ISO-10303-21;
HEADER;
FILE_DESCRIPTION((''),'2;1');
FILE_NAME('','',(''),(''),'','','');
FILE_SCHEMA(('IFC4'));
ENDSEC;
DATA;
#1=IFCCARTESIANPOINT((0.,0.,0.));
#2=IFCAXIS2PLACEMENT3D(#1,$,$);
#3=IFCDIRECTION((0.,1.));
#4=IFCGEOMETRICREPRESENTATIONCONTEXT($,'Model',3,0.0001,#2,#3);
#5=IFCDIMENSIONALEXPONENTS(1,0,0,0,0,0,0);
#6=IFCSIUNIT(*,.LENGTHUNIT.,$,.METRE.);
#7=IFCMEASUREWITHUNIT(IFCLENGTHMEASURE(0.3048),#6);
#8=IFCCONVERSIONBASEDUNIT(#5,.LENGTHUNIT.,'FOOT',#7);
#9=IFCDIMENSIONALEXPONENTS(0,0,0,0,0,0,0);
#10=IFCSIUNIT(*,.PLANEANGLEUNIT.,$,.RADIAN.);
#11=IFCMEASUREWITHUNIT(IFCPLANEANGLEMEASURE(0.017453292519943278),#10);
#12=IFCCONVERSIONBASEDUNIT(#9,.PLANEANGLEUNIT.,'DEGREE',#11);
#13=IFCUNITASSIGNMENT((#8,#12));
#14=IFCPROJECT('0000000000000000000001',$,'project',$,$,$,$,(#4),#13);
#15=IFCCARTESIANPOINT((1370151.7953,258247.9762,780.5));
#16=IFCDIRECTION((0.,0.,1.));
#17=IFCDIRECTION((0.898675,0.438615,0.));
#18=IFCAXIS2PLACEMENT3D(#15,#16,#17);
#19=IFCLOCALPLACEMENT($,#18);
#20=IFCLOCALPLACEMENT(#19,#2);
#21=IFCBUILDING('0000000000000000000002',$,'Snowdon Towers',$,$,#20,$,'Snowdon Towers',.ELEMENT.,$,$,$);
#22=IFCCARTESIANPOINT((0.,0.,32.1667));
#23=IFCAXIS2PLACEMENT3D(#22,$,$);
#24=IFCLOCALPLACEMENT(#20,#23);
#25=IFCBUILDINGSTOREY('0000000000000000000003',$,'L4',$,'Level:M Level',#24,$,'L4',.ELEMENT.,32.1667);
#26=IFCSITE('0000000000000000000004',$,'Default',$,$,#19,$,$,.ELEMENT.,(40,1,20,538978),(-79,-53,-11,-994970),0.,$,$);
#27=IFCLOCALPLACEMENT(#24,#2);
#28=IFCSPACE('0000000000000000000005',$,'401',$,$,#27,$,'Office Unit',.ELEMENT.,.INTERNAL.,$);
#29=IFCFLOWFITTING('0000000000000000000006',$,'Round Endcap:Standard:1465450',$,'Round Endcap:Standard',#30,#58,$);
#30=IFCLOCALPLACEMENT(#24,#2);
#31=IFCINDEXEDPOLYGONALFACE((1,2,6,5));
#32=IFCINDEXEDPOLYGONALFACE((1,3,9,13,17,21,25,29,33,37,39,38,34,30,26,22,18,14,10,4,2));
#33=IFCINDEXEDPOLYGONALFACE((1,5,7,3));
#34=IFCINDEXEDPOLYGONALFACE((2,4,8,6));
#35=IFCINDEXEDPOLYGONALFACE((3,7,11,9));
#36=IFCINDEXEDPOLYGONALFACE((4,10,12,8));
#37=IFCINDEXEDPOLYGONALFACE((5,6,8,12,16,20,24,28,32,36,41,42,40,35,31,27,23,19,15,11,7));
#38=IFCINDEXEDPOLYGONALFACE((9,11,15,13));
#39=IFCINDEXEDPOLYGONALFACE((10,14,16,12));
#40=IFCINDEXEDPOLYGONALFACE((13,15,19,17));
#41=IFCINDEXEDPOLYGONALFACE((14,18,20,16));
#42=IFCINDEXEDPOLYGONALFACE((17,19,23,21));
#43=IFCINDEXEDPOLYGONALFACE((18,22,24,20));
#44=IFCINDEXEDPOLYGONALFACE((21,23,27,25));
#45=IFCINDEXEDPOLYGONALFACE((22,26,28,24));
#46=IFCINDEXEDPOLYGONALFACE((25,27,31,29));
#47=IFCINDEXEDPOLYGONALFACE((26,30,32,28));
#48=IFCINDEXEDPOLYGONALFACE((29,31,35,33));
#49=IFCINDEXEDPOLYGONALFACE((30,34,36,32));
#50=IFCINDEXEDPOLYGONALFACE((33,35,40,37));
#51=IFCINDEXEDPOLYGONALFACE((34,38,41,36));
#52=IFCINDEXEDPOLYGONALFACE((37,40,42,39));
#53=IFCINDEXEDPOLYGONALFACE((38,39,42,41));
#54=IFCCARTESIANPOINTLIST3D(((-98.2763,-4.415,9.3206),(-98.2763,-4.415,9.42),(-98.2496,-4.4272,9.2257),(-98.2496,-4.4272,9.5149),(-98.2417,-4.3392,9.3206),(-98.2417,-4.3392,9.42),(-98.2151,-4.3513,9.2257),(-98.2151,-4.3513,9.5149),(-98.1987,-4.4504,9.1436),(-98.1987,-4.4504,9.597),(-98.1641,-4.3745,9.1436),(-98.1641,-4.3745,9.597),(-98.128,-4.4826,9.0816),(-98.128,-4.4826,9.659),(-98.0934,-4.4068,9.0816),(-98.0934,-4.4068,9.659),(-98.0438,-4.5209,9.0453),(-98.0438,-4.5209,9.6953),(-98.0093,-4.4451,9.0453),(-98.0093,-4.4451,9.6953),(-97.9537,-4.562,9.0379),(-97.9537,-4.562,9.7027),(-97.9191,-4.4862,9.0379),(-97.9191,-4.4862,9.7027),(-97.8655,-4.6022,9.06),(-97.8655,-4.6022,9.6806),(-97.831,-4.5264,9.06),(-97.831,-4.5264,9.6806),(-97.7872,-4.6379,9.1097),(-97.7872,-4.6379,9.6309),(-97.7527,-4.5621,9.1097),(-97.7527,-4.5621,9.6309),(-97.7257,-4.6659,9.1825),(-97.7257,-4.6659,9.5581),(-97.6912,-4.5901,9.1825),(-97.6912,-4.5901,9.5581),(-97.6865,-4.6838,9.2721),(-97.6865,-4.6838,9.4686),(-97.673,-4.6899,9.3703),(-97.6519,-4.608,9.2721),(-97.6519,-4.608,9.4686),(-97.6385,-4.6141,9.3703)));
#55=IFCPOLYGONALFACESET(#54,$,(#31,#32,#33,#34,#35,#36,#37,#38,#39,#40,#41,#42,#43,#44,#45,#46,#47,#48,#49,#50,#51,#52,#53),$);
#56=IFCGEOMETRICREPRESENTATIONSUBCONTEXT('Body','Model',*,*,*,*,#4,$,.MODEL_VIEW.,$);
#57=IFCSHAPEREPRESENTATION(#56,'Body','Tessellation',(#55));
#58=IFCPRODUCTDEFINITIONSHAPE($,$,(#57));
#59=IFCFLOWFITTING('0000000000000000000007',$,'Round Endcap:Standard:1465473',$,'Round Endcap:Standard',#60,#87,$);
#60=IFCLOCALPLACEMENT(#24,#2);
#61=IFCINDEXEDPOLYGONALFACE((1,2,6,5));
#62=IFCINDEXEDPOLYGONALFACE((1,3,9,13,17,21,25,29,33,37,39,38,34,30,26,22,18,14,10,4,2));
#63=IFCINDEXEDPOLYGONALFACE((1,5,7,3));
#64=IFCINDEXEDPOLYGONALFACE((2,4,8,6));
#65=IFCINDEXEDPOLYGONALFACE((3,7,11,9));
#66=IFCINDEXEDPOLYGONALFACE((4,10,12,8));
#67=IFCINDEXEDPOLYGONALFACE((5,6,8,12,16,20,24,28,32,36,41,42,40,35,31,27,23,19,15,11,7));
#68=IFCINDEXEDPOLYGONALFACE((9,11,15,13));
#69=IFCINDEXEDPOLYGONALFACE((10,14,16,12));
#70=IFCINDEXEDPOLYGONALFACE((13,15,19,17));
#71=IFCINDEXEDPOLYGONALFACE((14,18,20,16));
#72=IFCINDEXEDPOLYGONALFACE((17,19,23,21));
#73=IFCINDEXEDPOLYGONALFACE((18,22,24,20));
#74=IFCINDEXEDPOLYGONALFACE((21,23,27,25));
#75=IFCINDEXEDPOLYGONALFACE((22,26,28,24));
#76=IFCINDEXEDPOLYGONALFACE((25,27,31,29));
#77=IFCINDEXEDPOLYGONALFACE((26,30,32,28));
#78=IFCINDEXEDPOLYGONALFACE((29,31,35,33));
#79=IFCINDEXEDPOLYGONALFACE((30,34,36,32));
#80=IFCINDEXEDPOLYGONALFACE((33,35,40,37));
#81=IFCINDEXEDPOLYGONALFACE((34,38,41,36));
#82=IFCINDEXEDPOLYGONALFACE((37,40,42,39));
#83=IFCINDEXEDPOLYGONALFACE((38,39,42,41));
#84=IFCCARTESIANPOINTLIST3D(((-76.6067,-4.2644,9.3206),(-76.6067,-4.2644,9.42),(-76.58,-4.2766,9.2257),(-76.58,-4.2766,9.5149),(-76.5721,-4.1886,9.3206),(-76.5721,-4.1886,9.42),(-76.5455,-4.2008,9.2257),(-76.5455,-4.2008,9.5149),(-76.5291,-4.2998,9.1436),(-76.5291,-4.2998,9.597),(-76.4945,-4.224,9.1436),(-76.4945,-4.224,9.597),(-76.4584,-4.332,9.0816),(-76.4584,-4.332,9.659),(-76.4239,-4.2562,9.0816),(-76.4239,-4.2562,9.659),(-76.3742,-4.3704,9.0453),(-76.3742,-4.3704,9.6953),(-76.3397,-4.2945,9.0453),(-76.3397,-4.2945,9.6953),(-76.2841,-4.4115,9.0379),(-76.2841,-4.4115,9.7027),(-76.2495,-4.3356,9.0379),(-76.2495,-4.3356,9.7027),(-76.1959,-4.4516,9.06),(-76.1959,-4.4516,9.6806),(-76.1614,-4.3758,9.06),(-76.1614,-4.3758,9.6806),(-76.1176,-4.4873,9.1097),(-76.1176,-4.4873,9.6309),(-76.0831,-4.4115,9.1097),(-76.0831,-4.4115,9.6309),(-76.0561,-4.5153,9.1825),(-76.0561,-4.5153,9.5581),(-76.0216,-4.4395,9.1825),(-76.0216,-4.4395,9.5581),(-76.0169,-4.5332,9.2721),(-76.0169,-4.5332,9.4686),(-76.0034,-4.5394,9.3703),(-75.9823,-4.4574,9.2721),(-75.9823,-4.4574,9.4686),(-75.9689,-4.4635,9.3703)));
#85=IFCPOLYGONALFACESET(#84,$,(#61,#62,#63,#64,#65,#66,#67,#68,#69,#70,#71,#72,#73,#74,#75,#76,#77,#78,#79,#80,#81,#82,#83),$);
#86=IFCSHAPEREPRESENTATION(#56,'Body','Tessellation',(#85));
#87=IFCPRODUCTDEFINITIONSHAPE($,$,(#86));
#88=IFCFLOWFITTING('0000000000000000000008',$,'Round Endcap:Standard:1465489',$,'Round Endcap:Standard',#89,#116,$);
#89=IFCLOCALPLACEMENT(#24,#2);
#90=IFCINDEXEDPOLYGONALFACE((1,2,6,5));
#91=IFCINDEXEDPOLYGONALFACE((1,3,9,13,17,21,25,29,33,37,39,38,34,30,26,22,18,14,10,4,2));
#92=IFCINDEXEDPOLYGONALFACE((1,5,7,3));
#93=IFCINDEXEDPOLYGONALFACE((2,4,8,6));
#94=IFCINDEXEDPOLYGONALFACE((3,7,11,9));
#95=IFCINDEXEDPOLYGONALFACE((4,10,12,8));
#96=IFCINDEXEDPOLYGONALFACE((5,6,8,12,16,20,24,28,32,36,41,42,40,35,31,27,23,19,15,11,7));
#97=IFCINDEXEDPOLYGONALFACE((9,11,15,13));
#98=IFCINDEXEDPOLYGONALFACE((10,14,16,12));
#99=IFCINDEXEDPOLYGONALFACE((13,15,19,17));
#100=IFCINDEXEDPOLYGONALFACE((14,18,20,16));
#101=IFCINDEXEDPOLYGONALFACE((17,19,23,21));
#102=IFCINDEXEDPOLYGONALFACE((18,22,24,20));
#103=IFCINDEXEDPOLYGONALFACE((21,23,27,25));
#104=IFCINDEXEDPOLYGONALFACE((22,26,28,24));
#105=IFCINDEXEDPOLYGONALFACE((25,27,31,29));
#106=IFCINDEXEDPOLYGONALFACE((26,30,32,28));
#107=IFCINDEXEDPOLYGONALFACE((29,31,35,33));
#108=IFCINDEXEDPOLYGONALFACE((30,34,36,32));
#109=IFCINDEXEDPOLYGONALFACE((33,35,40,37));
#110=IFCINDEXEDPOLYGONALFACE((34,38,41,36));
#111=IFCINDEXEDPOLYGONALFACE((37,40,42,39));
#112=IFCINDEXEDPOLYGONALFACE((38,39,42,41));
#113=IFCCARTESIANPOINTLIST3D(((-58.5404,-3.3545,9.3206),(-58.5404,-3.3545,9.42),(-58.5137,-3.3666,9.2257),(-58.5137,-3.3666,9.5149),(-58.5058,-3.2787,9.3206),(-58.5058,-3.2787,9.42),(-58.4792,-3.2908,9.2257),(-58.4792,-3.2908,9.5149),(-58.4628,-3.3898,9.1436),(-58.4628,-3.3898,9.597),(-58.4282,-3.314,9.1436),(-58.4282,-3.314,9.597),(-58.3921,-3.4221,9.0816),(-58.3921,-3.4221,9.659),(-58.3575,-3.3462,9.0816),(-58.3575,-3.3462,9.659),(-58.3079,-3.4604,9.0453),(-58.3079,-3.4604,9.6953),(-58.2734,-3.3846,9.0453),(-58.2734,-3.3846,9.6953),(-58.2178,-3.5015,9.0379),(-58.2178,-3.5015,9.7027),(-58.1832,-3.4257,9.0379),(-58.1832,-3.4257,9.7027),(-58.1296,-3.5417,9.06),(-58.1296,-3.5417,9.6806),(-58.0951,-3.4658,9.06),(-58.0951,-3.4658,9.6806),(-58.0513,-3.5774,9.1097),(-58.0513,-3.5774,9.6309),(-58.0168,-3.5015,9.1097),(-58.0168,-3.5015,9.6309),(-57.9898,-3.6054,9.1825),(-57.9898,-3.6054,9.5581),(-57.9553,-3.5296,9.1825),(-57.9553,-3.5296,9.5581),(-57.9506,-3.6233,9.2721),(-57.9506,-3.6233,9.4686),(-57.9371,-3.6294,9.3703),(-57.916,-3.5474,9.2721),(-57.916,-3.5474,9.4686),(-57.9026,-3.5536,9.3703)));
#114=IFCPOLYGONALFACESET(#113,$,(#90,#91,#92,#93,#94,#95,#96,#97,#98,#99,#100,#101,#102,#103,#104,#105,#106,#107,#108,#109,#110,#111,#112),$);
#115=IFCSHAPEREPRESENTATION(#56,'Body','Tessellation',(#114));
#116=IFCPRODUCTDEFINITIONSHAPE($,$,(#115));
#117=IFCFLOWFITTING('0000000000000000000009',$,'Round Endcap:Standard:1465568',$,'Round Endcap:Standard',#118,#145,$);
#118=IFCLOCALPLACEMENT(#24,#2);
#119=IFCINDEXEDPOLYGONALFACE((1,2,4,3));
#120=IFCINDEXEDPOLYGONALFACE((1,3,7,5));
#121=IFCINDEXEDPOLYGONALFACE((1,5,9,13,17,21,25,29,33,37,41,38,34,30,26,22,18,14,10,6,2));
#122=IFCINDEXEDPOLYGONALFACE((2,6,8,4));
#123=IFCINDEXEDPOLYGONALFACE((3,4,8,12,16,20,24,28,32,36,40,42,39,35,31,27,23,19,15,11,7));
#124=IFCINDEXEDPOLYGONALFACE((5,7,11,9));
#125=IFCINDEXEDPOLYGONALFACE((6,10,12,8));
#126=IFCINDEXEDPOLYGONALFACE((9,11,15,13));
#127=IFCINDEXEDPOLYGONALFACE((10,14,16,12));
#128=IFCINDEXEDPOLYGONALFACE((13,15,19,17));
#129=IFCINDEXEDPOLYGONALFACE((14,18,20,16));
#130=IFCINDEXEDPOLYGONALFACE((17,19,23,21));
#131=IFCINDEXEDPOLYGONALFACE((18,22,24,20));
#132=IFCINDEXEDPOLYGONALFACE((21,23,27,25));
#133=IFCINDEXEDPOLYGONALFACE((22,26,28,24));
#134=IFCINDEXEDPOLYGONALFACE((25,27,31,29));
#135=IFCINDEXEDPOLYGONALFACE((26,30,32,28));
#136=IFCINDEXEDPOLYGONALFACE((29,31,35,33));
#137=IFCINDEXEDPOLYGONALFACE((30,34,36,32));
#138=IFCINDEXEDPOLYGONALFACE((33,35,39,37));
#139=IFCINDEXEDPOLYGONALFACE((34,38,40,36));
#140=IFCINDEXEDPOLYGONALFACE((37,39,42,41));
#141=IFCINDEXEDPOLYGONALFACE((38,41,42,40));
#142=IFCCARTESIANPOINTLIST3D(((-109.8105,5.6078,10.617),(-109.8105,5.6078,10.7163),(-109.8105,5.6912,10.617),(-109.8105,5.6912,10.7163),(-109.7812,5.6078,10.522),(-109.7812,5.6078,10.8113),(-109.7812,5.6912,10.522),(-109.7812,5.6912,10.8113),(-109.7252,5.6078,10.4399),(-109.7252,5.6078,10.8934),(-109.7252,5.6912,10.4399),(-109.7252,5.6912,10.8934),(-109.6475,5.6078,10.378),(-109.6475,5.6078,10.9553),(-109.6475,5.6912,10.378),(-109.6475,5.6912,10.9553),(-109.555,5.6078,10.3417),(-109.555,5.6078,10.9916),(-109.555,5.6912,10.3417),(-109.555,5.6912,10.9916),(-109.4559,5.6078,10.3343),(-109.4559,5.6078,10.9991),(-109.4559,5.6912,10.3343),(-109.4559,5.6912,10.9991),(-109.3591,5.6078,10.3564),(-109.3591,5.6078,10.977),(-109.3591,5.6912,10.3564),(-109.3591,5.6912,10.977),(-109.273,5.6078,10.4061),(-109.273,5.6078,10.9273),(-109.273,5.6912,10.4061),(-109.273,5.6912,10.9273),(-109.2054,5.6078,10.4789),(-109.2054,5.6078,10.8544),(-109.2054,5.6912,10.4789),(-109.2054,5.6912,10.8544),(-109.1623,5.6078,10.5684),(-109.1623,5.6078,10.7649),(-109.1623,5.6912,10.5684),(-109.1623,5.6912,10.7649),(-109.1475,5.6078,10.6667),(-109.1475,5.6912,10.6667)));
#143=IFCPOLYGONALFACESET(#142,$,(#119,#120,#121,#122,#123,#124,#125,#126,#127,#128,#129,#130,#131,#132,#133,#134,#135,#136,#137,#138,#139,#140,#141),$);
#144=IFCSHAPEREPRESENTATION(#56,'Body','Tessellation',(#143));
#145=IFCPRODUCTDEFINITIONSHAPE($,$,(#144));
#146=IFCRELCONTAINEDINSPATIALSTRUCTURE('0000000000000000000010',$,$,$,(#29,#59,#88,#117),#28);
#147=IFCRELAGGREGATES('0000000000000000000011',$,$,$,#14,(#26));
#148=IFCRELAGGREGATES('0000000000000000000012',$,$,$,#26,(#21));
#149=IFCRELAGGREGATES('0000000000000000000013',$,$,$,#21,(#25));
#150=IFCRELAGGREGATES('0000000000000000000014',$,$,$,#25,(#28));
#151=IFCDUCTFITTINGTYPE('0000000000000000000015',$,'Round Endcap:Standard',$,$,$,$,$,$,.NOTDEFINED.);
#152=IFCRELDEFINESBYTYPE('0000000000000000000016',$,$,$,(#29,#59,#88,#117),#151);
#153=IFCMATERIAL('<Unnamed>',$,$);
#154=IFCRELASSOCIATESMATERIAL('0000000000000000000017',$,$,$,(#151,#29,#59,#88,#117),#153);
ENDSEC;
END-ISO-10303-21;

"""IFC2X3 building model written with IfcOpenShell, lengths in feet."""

from ifc_helpers import new_model, entity, si_unit, converted_unit, direction, frame, frame_2d, origin, place, context, subcontext, project, spatial, circle, extrude, source, transform, mapped, material, type_object, type_shapes, element, save


model = new_model("IFC2X3")

# Units and contexts
model_context = context("Model", 3, precision=0.0001, world=origin(), true_north=direction((0.0, 1.0)))
body_context = subcontext(model_context, "Body", "Model", "MODEL_VIEW")
ifc_project = project(units=[converted_unit("LENGTHUNIT", "FOOT", entity("IfcLengthMeasure", 0.3048), si_unit("LENGTHUNIT", "METRE"), dimensions=[1, 0, 0, 0, 0, 0, 0]), converted_unit("PLANEANGLEUNIT", "DEGREE", entity("IfcPlaneAngleMeasure", 0.017453292519943278), si_unit("PLANEANGLEUNIT", "RADIAN"), dimensions=[0, 0, 0, 0, 0, 0, 0])], contexts=[model_context])

# Site, building, storey
site_placement = place(None, frame((1370151.7953, 258247.9762, 780.5), z_axis=(0.0, 0.0, 1.0), x_axis=(0.898675, 0.438615, 0.0)))
site = spatial("IfcSite", under=ifc_project, at=site_placement, Name="Default", CompositionType="ELEMENT", RefLatitude=(40, 1, 20, 538978), RefLongitude=(-79, -53, -11, -994970), RefElevation=0.0)
building_placement = place(site_placement, origin())
building = spatial("IfcBuilding", under=site, at=building_placement, Name="Snowdon Towers", LongName="Snowdon Towers", CompositionType="ELEMENT")
storey_placement = place(building_placement, frame((0.0, 0.0, 32.1667)))
storey = spatial("IfcBuildingStorey", under=building, at=storey_placement, Name="L4", ObjectType="Level:M Level", LongName="L4", CompositionType="ELEMENT", Elevation=32.1667)

# Shared definitions
space_placement = place(storey_placement, origin())
space = spatial("IfcSpace", under=storey, at=space_placement, Name="401", LongName="Office Unit", CompositionType="ELEMENT", InteriorOrExteriorSpace="INTERNAL")

# Flow fittings
ifc_material = material(Name="<Unnamed>")
duct_fitting_type = type_object("IfcDuctFittingType", Name="Round Endcap:Standard", PredefinedType="NOTDEFINED", material=ifc_material)
shared_shape = source(origin(), body_context, "Body", "SweptSolid", [
    extrude(circle(Radius=0.3333, at=frame_2d((0.0, 0.0), x_axis=(1.0, 0.0))), frame((0.0, 0.0, 0.0), z_axis=(1.0, 0.0, 0.0), x_axis=(0.0, 1.0, 0.0)), (0.0, 0.0, 1.0), 0.0833),
])
type_shapes(duct_fitting_type, [shared_shape])
for number, where, z_axis, x_axis, name in (
    (1, (-97.9418, -4.4759, 9.3703), (0.0, 0.0, 1.0), (-0.414693, -0.909961, 0.0), "Round Endcap:Standard:1465450"),
    (2, (-76.2722, -4.3253, 9.3703), (0.0, 0.0, 1.0), (-0.414693, -0.909961, 0.0), "Round Endcap:Standard:1465473"),
    (3, (-58.2059, -3.4153, 9.3703), (0.0, 0.0, 1.0), (-0.414693, -0.909961, 0.0), "Round Endcap:Standard:1465489"),
    (4, (-109.4808, 5.6912, 10.6667), (0.0, 0.0, 1.0), (0.0, -1.0, 0.0), "Round Endcap:Standard:1465568"),
):
    element("IfcFlowFitting", number, at=place(space_placement, frame(where, z_axis=z_axis, x_axis=x_axis)), inside=space, type_object=duct_fitting_type, material=ifc_material, Name=name, ObjectType="Round Endcap:Standard", context=body_context, shape_type="MappedRepresentation", body=[
        mapped(shared_shape, transform((0.0, 0.0, 0.0), scale=1.0)),
    ])

save(model, "model.ifc")
